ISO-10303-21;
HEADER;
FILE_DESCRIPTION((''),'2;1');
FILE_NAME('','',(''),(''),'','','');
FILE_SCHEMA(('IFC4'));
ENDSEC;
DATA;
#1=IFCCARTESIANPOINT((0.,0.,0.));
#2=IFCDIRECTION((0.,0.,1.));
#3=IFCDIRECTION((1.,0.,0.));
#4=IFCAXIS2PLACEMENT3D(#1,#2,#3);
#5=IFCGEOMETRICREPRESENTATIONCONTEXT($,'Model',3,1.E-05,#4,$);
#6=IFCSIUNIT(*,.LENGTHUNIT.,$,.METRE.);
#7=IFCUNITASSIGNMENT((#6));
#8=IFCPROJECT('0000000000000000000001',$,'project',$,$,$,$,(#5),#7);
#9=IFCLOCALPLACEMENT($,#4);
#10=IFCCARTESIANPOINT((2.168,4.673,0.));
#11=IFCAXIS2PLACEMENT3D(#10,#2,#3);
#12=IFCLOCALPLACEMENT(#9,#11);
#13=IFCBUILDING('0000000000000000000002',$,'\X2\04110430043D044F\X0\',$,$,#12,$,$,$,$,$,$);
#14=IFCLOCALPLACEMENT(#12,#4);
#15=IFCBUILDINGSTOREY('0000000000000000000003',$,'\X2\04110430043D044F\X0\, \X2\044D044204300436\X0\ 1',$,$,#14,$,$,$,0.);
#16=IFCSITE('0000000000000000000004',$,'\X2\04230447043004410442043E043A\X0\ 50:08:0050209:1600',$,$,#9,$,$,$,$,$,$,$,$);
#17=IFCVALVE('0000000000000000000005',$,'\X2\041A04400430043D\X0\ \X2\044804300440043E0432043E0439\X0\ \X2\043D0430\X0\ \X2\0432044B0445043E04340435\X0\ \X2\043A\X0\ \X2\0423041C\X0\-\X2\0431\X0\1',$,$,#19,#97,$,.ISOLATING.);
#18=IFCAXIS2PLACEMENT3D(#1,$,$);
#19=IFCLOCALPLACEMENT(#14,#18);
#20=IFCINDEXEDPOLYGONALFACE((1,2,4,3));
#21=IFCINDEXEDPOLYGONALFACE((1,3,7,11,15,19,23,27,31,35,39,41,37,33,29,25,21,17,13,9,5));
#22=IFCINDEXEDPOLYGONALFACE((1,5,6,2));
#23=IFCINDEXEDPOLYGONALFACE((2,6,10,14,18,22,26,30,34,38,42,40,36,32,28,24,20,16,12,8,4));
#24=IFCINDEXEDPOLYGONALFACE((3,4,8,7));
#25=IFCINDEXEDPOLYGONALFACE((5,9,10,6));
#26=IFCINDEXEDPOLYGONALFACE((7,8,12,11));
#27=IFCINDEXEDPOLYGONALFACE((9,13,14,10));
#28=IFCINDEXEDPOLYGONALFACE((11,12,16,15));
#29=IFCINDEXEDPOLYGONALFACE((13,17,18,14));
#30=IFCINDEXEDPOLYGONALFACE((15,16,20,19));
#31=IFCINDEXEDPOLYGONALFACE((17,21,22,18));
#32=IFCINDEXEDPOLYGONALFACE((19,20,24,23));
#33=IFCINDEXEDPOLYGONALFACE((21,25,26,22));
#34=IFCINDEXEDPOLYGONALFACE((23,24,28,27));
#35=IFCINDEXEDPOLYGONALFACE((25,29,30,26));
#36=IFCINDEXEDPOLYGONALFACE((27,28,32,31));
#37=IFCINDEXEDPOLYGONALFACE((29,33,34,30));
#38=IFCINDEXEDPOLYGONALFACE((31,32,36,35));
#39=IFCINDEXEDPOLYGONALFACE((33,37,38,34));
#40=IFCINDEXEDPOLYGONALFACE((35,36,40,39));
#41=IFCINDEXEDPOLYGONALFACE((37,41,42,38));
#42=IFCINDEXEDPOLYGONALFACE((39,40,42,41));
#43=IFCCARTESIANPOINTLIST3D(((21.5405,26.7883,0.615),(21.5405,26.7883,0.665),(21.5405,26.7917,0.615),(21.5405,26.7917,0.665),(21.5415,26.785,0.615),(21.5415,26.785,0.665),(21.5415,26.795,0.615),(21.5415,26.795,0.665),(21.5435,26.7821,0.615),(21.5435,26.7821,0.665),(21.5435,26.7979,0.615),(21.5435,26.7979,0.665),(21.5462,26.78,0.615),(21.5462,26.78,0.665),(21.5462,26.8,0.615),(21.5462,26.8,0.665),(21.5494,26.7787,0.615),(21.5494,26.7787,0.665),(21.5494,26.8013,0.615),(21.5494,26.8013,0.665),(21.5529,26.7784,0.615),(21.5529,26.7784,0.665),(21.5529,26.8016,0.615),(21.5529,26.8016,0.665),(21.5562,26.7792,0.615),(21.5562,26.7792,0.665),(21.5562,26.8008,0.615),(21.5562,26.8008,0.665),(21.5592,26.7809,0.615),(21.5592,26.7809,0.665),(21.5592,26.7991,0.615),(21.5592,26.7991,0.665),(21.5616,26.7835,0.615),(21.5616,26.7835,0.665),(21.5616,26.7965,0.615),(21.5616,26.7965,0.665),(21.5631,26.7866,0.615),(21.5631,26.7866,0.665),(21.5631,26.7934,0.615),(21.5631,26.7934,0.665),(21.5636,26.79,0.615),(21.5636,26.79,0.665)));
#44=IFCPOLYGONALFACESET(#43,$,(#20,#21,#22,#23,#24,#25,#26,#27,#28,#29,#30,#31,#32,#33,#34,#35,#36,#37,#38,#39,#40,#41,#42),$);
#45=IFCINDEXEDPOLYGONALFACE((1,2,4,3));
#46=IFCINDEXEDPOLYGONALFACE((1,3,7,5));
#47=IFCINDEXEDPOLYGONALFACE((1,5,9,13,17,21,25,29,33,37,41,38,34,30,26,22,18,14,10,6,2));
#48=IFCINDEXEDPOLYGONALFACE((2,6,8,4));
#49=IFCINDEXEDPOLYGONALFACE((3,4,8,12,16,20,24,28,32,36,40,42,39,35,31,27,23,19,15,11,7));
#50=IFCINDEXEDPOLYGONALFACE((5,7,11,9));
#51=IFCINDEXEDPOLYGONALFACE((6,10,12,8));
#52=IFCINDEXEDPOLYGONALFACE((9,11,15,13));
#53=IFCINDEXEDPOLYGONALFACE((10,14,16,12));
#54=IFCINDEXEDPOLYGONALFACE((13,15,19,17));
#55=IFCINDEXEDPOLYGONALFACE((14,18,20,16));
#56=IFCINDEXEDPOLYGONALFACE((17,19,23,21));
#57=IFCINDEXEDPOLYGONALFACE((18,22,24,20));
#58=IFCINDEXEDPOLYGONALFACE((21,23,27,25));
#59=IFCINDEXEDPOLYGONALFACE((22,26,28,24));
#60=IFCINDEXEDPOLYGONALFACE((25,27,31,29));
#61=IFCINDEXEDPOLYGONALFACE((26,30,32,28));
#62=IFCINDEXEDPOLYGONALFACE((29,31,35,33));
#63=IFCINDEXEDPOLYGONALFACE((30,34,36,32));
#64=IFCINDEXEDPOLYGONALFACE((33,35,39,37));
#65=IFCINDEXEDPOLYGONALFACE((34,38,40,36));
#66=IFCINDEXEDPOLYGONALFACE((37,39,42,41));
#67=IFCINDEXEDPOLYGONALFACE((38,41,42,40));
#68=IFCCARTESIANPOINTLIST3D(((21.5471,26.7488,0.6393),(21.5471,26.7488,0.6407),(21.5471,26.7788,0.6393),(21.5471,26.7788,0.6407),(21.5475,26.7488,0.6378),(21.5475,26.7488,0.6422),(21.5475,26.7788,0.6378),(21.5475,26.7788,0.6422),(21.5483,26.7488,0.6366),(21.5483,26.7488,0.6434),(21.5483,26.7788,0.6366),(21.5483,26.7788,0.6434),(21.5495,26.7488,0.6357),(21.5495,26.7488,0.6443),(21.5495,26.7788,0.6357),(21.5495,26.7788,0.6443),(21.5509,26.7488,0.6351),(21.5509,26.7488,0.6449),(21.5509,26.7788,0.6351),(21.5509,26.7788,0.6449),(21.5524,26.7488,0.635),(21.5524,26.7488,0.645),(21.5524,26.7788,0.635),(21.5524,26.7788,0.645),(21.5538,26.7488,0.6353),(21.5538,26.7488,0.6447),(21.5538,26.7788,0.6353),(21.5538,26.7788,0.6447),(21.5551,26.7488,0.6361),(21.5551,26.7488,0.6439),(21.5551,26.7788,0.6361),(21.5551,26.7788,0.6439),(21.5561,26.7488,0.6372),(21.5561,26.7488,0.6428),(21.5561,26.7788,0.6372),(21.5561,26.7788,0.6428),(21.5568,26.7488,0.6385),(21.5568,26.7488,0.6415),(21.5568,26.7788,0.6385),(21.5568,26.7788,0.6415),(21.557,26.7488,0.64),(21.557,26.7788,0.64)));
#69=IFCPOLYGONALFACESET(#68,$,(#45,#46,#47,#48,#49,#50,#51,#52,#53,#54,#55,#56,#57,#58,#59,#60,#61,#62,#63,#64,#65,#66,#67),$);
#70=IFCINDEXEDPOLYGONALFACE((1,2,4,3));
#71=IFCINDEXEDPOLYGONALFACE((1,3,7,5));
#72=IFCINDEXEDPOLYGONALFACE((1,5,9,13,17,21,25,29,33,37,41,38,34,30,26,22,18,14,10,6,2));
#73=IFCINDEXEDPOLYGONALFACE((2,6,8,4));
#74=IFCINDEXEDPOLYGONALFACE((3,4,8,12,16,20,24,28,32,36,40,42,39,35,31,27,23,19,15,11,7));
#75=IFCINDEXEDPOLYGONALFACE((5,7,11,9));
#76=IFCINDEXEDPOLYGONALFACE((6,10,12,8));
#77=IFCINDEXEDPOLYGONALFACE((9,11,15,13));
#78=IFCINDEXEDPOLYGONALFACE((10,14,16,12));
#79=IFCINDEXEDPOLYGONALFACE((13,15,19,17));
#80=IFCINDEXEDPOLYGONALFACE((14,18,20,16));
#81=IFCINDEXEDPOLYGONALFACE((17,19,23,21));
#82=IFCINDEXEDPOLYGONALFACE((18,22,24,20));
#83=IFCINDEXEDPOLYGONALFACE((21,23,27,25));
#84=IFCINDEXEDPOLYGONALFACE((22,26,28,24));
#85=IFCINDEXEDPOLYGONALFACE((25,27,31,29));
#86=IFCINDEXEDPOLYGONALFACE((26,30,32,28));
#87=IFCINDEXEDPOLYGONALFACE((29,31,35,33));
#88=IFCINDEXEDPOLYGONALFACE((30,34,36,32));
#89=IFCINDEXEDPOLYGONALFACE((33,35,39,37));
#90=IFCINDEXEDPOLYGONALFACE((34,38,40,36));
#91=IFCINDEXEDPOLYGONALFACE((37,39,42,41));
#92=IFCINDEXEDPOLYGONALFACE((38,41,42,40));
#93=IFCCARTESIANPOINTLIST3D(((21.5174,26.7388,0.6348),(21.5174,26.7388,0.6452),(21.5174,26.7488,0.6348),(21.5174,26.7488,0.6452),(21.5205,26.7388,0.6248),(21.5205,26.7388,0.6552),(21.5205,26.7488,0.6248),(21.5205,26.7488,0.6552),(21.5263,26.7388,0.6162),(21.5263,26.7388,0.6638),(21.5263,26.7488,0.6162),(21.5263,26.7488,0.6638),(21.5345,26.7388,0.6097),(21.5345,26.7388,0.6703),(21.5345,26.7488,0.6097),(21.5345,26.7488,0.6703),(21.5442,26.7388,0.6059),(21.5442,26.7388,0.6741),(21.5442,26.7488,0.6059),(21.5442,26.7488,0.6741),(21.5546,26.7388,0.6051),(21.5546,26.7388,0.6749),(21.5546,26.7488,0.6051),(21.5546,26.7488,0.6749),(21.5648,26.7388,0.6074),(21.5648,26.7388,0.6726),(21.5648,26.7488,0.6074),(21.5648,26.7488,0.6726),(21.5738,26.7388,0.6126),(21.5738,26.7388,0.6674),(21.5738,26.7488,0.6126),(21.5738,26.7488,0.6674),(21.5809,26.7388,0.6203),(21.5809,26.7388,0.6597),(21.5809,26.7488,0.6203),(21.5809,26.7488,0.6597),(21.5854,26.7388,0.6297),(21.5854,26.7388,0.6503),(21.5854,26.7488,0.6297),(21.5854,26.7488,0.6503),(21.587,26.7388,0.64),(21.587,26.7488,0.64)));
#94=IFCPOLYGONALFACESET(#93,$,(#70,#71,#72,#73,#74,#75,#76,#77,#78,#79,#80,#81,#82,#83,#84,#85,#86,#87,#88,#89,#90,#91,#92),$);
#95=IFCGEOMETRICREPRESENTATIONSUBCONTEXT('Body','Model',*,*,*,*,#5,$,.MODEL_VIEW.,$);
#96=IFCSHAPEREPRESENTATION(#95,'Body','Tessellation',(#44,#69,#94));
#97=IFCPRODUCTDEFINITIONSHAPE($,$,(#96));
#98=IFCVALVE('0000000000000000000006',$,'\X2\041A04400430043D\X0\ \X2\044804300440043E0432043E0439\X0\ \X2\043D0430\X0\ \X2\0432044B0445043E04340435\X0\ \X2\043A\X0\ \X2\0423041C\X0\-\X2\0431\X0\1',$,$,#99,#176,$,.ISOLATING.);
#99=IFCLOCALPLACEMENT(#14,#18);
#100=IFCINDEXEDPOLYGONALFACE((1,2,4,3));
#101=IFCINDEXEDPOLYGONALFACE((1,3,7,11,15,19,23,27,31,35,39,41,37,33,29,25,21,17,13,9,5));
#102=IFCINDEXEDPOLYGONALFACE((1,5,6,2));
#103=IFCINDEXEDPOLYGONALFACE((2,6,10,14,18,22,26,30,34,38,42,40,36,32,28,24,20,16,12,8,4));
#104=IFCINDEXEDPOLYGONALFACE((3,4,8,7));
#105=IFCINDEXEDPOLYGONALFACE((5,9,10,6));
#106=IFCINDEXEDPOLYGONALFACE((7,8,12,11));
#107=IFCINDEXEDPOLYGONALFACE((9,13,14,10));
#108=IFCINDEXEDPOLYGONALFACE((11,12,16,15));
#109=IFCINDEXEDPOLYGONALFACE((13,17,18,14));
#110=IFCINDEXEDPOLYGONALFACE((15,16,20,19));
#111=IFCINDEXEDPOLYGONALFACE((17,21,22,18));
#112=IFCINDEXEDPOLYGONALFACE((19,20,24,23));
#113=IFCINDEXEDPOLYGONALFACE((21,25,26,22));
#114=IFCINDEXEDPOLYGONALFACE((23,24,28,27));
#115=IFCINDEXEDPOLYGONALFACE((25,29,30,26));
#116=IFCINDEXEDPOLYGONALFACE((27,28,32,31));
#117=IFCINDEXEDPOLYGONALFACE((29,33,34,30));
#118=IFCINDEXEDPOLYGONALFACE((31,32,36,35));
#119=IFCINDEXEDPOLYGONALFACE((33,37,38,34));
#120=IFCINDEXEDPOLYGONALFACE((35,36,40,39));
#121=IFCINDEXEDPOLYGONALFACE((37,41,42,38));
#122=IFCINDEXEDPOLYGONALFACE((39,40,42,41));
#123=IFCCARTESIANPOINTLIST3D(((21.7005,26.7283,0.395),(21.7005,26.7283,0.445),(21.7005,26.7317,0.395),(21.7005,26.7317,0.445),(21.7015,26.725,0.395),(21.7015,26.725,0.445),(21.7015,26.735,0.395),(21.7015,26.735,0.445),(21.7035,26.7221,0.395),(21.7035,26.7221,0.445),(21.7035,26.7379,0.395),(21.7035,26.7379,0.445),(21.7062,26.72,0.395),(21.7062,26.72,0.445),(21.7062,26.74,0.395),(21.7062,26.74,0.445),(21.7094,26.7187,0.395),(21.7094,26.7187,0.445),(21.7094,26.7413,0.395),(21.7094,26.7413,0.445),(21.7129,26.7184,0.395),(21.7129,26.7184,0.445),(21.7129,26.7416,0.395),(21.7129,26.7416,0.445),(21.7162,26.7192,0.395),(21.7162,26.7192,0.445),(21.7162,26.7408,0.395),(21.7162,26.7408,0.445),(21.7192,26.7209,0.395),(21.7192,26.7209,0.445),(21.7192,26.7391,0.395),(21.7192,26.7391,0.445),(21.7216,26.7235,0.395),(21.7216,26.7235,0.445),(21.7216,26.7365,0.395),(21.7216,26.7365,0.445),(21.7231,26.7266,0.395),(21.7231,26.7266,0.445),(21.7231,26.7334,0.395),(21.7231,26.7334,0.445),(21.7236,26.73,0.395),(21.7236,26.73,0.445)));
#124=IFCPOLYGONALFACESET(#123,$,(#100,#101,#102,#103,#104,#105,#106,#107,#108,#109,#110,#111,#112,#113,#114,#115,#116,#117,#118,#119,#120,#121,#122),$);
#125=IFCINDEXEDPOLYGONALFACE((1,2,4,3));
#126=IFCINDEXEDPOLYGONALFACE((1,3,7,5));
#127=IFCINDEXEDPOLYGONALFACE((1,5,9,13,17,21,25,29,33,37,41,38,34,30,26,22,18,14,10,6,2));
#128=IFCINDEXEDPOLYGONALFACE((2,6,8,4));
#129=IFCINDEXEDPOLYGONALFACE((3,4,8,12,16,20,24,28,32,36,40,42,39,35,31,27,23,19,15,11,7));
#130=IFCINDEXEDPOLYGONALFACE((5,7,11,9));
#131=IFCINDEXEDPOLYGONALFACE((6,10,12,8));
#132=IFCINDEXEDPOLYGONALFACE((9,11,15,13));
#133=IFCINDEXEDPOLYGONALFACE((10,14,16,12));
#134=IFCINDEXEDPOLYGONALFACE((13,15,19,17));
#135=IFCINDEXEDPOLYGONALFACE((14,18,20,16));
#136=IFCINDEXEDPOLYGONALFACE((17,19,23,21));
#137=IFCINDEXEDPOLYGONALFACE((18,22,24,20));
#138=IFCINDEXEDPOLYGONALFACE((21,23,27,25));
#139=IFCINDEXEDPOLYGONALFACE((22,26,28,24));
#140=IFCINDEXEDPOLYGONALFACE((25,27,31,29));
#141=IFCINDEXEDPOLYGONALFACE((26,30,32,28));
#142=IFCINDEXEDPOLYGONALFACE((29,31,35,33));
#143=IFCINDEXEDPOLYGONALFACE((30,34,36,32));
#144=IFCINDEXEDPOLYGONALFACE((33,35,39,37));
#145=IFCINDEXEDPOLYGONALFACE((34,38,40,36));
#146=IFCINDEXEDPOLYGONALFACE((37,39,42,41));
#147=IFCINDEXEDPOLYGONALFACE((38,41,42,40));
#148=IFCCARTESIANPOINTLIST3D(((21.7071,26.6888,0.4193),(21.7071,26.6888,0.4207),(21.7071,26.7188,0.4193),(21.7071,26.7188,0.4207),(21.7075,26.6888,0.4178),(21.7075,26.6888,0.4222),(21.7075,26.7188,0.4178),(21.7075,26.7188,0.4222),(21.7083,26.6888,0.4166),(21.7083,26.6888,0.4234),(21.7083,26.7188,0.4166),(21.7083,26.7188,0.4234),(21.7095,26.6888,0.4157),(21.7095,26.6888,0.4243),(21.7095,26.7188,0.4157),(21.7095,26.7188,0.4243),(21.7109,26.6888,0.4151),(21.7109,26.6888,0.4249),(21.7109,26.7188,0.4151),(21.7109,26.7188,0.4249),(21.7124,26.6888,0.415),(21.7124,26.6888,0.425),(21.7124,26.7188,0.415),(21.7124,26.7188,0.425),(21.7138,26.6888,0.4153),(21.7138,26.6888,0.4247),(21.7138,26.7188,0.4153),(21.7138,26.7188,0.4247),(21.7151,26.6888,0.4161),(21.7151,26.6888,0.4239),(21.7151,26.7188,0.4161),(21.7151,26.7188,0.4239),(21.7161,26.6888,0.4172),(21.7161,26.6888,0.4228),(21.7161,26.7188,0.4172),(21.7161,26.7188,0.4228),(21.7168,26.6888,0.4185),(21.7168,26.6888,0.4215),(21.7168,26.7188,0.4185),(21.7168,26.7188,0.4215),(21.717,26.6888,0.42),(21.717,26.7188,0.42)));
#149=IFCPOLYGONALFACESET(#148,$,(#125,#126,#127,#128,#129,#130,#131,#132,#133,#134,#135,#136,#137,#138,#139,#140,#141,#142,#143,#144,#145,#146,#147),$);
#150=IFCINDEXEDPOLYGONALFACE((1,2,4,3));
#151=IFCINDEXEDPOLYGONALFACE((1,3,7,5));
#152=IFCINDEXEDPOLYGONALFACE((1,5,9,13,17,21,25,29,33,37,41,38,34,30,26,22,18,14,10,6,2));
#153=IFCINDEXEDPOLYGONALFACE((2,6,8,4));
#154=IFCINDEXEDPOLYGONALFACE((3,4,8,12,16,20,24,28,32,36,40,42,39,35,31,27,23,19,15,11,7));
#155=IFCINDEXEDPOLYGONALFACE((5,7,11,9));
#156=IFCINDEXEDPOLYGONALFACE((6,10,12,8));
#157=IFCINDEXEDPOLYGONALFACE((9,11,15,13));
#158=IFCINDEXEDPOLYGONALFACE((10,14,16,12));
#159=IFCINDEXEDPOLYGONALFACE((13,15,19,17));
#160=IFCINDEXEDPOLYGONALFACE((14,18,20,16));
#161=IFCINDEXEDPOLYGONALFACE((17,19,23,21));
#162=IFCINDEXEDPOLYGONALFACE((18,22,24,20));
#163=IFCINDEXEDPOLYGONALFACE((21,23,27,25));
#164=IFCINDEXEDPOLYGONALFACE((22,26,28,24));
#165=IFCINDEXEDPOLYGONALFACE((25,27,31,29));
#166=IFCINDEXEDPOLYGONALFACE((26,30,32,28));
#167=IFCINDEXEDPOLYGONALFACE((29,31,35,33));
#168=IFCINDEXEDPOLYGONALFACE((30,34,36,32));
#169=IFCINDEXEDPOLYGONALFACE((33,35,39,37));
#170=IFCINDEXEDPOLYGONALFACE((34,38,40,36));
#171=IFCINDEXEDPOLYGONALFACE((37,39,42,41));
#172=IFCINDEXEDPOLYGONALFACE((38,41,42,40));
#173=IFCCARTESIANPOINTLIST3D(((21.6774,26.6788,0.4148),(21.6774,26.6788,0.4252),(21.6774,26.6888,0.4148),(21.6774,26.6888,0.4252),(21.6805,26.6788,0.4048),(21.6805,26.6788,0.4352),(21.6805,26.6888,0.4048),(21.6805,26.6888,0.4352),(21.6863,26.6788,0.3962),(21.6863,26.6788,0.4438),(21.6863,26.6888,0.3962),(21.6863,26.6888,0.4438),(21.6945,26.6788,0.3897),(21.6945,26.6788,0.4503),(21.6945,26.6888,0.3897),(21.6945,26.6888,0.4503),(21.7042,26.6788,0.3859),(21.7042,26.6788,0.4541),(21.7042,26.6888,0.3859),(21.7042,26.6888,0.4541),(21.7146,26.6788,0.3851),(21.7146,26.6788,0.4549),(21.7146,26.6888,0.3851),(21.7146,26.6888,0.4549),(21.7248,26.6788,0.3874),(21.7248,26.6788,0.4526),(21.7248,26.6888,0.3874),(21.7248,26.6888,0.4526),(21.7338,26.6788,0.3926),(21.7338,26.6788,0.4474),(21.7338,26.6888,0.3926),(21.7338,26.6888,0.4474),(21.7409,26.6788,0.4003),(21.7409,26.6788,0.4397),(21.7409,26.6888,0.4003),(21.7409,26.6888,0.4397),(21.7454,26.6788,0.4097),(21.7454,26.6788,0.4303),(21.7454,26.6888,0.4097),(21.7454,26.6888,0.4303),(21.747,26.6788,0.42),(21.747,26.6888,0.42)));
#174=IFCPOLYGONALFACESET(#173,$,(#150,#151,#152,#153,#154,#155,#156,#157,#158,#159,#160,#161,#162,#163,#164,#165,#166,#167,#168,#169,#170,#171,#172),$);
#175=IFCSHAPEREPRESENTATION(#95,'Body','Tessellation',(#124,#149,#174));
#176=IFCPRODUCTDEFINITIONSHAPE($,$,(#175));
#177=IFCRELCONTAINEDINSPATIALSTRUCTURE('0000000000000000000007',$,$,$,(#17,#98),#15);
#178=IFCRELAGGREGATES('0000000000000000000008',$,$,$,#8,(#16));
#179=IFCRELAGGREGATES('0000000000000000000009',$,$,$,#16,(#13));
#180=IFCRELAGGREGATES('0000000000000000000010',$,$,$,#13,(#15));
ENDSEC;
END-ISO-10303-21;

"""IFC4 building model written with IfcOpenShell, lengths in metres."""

from ifc_helpers import new_model, si_unit, frame, origin_with_axes, origin_2d, place, context, subcontext, project, spatial, circle, extrude, element, save


model = new_model("IFC4")

# Units and contexts
model_context = context("Model", 3, precision=1e-05, world=origin_with_axes())
body_context = subcontext(model_context, "Body", "Model", "MODEL_VIEW")
ifc_project = project(units=[si_unit("LENGTHUNIT", "METRE")], contexts=[model_context])

# Site, building, storey
site_placement = place(None, origin_with_axes())
site = spatial("IfcSite", under=ifc_project, at=site_placement, Name="Участок 50:08:0050209:1600")
building_placement = place(site_placement, frame((2.168, 4.673, 0.0), z_axis=(0.0, 0.0, 1.0), x_axis=(1.0, 0.0, 0.0)))
building = spatial("IfcBuilding", under=site, at=building_placement, Name="Баня")
storey_placement = place(building_placement, origin_with_axes())
storey = spatial("IfcBuildingStorey", under=building, at=storey_placement, Name="Баня, этаж 1", Elevation=0.0)

# Valves
valve_1_placement = place(storey_placement, origin_with_axes())
element("IfcValve", 1, at=valve_1_placement, inside=storey, Name="Кран шаровой на выходе к УМ-б1", PredefinedType="ISOLATING", context=body_context, shape_type="SweptSolid", body=[
    extrude(circle(Radius=0.0116, at=origin_2d()), frame((21.552, 26.79, 0.615), z_axis=(0.0, 0.0, 1.0), x_axis=(1.0, 0.0, 0.0)), (0.0, 0.0, 1.0), 0.05),
    extrude(circle(Radius=0.005, at=origin_2d()), frame((21.552, 26.7788, 0.64), z_axis=(0.0, -1.0, 0.0), x_axis=(1.0, 0.0, 0.0)), (0.0, 0.0, 1.0), 0.03),
    extrude(circle(Radius=0.035, at=origin_2d()), frame((21.552, 26.7488, 0.64), z_axis=(0.0, -1.0, 0.0), x_axis=(1.0, 0.0, 0.0)), (0.0, 0.0, 1.0), 0.01),
])
valve_2_placement = place(storey_placement, origin_with_axes())
element("IfcValve", 2, at=valve_2_placement, inside=storey, Name="Кран шаровой на выходе к УМ-б1", PredefinedType="ISOLATING", context=body_context, shape_type="SweptSolid", body=[
    extrude(circle(Radius=0.0116, at=origin_2d()), frame((21.712, 26.73, 0.395), z_axis=(0.0, 0.0, 1.0), x_axis=(1.0, 0.0, 0.0)), (0.0, 0.0, 1.0), 0.05),
    extrude(circle(Radius=0.005, at=origin_2d()), frame((21.712, 26.7188, 0.42), z_axis=(0.0, -1.0, 0.0), x_axis=(1.0, 0.0, 0.0)), (0.0, 0.0, 1.0), 0.03),
    extrude(circle(Radius=0.035, at=origin_2d()), frame((21.712, 26.6888, 0.42), z_axis=(0.0, -1.0, 0.0), x_axis=(1.0, 0.0, 0.0)), (0.0, 0.0, 1.0), 0.01),
])

save(model, "model.ifc")
